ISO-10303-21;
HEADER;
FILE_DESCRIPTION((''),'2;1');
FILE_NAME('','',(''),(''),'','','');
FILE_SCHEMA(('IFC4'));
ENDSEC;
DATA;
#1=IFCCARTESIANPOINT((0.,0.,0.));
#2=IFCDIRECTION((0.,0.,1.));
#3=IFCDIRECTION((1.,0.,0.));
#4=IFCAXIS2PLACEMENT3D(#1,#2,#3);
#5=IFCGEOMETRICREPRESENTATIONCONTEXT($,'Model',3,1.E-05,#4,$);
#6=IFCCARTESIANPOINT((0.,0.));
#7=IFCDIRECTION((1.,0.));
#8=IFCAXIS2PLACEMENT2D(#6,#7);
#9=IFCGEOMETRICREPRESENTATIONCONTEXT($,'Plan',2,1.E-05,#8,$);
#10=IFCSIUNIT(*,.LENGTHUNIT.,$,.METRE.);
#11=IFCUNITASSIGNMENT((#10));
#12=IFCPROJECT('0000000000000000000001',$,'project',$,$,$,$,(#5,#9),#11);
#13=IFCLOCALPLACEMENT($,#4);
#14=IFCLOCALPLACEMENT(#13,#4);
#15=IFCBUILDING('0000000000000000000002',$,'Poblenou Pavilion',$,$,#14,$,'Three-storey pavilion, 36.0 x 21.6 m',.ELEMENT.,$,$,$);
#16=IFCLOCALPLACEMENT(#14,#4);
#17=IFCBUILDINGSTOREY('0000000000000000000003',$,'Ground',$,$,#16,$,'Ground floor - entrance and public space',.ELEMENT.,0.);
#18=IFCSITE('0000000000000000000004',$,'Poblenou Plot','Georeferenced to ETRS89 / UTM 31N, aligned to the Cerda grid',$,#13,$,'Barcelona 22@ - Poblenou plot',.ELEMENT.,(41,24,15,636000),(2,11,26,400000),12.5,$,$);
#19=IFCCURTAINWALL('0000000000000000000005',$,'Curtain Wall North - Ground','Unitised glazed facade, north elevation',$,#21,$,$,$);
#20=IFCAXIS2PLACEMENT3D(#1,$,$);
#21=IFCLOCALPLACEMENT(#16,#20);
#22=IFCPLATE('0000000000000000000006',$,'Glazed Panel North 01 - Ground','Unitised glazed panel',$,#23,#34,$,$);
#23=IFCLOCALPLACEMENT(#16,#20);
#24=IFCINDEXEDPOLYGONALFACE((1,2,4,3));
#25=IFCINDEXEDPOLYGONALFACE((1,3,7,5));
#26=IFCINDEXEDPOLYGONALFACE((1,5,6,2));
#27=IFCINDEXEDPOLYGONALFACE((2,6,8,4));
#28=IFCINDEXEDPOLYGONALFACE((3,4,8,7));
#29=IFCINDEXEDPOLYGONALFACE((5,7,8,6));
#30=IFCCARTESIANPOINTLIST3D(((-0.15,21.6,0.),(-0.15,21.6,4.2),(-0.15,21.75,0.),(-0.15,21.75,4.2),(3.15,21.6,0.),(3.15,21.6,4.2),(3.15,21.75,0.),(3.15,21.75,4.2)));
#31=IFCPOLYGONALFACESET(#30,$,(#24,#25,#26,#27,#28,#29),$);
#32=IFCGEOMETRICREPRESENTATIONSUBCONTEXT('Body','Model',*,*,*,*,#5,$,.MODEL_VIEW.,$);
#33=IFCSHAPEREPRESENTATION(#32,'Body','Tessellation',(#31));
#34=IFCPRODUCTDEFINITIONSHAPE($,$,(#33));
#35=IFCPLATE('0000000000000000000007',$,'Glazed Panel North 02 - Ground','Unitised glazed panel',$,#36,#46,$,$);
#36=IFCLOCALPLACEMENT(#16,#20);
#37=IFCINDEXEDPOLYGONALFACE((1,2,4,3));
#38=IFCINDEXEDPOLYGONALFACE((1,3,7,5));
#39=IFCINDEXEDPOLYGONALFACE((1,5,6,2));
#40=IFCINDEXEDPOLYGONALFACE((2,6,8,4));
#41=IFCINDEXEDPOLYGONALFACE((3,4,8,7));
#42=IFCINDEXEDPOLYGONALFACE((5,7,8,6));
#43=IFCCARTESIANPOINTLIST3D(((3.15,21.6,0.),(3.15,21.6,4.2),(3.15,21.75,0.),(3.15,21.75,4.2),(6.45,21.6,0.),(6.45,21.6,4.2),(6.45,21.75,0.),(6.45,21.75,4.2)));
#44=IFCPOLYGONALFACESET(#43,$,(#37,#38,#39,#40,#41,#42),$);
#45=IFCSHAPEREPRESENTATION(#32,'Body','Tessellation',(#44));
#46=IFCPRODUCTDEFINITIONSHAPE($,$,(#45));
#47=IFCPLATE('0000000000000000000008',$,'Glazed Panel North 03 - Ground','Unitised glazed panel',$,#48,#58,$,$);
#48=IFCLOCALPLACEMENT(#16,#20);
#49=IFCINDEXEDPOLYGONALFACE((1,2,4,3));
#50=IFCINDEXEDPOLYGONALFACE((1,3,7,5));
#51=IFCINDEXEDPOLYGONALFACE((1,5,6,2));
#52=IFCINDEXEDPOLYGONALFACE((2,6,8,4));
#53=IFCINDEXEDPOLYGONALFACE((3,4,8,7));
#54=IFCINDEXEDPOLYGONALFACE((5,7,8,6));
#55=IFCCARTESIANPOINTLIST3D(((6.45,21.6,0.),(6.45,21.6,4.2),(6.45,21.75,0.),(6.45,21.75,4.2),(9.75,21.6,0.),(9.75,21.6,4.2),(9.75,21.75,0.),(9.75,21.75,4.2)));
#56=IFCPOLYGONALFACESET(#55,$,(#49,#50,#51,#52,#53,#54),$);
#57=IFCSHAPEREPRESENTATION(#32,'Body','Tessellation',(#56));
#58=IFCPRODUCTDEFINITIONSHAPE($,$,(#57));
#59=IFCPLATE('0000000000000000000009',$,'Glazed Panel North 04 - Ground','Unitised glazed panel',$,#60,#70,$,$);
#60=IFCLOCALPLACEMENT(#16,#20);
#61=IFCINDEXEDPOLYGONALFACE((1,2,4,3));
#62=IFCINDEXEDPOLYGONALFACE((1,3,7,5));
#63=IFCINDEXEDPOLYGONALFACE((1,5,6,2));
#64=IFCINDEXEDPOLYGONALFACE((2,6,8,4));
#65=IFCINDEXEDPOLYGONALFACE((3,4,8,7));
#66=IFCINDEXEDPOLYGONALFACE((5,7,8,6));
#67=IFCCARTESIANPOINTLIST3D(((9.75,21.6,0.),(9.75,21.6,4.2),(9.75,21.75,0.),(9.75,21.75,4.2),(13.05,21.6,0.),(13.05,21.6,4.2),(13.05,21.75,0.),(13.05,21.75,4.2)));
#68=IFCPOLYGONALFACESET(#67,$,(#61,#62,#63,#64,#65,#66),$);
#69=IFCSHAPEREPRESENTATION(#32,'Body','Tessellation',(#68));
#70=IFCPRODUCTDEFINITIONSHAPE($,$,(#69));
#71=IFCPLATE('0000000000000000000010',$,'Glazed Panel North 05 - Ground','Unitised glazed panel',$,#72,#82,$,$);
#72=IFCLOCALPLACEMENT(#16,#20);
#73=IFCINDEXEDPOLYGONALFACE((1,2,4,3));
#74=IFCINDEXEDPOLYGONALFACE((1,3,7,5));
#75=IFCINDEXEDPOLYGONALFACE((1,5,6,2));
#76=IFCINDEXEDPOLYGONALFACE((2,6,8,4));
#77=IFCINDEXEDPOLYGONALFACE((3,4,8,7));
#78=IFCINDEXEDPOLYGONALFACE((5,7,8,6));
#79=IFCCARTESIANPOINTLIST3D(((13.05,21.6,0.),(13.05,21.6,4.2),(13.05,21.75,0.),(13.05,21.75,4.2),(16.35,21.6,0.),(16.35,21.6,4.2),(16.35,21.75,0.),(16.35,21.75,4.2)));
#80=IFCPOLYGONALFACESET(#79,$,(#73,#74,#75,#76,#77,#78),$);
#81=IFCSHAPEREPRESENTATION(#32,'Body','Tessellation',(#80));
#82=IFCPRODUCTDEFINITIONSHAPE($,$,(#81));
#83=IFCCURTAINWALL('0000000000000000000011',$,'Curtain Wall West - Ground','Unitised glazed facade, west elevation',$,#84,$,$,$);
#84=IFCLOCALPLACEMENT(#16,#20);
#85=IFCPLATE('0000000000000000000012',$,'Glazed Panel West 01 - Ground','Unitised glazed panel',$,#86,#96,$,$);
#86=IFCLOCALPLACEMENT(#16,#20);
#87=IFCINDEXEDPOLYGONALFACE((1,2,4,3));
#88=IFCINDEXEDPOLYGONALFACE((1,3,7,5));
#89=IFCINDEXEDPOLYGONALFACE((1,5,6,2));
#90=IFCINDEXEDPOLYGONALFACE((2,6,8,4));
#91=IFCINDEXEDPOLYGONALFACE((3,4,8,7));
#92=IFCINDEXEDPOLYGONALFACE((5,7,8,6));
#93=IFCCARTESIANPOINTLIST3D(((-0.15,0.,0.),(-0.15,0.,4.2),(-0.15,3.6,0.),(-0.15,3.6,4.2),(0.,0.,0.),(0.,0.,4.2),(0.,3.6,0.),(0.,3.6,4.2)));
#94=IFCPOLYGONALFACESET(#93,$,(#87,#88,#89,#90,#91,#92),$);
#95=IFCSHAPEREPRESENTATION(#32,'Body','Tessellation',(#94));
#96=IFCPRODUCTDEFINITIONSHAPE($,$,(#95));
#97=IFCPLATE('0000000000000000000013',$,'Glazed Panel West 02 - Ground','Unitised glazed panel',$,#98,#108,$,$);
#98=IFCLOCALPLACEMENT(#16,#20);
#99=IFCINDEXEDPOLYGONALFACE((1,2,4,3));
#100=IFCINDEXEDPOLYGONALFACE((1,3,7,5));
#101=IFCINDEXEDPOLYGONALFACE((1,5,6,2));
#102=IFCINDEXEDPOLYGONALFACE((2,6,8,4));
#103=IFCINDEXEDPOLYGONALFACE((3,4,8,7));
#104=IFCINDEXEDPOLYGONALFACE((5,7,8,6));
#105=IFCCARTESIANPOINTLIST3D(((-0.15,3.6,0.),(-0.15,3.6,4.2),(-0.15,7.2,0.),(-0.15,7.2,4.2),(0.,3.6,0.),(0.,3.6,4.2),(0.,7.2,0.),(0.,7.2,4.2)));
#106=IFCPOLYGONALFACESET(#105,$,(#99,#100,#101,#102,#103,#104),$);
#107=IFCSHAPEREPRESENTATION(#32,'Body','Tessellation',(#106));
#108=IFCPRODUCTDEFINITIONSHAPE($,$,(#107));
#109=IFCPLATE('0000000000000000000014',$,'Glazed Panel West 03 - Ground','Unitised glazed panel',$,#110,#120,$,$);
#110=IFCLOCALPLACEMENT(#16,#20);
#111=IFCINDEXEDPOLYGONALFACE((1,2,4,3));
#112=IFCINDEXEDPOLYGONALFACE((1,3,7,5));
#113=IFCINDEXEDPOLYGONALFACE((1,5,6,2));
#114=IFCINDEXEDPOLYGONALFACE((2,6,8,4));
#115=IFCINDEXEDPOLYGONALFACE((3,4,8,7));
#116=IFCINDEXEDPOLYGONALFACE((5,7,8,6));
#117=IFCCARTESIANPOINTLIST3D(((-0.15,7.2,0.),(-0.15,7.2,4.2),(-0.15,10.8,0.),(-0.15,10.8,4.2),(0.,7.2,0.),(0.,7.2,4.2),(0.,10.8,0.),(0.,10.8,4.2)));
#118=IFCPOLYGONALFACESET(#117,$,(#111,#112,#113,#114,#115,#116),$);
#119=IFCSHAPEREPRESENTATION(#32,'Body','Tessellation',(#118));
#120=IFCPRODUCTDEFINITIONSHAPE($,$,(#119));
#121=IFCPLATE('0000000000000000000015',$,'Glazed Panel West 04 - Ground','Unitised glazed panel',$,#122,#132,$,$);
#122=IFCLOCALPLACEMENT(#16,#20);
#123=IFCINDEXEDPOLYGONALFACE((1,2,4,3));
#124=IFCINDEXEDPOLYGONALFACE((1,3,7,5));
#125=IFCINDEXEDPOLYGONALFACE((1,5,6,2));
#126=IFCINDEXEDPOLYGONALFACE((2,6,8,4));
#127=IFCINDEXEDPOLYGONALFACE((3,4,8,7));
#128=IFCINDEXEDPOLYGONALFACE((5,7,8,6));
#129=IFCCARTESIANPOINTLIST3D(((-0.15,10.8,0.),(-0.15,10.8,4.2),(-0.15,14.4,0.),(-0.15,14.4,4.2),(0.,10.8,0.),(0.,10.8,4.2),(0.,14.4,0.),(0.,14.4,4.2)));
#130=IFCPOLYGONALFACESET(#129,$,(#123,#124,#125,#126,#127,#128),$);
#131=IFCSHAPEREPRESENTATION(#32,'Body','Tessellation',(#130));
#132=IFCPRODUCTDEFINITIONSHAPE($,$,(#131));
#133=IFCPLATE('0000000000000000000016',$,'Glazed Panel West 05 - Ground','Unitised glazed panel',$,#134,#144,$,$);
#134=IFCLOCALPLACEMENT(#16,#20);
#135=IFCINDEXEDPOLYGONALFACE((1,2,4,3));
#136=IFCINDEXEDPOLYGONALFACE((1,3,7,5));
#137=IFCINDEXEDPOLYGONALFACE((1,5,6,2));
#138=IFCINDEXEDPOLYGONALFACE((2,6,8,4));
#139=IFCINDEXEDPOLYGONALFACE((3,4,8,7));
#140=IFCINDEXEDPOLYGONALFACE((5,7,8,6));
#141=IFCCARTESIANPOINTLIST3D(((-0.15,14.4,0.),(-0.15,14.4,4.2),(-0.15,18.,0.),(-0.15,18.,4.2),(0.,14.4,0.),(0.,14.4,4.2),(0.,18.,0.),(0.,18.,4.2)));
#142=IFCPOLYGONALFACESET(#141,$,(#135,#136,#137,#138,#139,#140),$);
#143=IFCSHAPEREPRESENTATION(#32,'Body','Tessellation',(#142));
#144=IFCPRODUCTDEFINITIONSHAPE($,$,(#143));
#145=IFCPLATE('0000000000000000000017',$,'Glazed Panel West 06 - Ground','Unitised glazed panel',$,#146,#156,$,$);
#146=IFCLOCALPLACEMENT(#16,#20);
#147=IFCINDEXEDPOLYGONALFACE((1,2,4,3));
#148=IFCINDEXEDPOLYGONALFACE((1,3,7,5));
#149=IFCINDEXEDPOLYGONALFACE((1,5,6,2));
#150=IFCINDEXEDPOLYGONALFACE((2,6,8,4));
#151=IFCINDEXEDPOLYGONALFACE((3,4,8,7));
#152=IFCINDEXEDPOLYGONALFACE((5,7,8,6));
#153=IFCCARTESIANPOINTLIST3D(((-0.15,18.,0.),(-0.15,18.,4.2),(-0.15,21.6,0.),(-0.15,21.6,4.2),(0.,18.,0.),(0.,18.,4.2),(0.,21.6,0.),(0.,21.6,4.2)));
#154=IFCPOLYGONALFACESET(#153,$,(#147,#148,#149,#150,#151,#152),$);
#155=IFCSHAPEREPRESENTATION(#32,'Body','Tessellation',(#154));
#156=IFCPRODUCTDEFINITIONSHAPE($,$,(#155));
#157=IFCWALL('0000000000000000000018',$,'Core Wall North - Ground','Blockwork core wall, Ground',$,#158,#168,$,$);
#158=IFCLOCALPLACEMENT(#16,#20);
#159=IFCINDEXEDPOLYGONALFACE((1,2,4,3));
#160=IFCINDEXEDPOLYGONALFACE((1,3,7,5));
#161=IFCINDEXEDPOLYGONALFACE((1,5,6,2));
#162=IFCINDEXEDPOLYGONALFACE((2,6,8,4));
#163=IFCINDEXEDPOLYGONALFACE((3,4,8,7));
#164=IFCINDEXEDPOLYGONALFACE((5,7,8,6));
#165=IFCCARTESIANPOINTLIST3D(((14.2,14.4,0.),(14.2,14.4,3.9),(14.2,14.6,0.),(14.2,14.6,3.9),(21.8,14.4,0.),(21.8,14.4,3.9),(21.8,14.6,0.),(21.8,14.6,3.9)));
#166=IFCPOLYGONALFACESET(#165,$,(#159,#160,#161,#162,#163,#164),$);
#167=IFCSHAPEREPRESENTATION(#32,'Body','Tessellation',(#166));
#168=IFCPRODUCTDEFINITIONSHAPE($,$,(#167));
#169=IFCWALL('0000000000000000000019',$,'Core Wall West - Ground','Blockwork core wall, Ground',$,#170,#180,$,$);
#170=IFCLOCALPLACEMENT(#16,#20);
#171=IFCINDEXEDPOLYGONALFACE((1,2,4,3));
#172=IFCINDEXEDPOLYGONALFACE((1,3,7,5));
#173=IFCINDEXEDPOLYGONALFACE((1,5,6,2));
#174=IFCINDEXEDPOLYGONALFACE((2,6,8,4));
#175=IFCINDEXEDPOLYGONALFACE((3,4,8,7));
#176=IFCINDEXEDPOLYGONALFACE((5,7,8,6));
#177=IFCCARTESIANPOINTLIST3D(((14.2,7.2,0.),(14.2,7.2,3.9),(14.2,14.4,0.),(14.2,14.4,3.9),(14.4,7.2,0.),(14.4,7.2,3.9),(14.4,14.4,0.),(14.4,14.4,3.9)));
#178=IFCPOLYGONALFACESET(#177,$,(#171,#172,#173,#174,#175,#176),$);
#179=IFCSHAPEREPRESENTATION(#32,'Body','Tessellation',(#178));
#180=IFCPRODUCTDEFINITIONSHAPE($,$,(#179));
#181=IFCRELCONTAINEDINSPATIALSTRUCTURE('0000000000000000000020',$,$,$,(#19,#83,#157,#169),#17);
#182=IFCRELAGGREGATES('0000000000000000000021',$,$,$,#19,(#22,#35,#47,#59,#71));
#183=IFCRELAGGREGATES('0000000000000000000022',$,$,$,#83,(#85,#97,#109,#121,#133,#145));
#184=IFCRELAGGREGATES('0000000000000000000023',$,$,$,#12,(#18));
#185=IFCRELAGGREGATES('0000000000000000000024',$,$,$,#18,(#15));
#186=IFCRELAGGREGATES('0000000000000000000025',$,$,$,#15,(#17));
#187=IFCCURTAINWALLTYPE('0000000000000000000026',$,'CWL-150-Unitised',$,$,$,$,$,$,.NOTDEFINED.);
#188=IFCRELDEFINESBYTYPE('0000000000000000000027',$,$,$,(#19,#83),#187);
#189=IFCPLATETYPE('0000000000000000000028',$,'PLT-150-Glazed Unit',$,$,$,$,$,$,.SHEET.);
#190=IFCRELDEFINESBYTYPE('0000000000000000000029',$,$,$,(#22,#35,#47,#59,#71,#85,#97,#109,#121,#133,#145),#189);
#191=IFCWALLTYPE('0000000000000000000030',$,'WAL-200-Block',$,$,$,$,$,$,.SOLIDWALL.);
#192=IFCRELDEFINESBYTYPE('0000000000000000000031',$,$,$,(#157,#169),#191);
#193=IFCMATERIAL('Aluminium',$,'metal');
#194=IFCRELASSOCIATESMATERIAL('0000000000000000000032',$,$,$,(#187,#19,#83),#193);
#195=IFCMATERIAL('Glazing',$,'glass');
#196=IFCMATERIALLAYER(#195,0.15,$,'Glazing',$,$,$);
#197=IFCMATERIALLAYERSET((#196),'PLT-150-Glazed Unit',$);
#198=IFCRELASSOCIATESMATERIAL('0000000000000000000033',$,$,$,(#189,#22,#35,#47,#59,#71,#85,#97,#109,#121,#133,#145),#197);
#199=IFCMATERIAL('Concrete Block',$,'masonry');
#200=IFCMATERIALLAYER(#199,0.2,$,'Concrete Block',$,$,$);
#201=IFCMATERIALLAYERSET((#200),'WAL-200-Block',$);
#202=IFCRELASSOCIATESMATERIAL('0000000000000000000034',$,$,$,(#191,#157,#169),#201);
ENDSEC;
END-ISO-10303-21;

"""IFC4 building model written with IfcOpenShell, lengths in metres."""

from ifc_helpers import new_model, si_unit, frame, origin_with_axes, origin_2d_with_axis, place, context, subcontext, project, spatial, line, indexed_curve, outline, extrude, material, layer, layer_set, layer_usage, type_object, element, aggregate, save


model = new_model("IFC4")

# Units and contexts
model_context = context("Model", 3, precision=1e-05, world=origin_with_axes())
plan_context = context("Plan", 2, precision=1e-05, world=origin_2d_with_axis())
body_context = subcontext(model_context, "Body", "Model", "MODEL_VIEW")
ifc_project = project(units=[si_unit("LENGTHUNIT", "METRE")], contexts=[model_context, plan_context])

# Site, building, storey
site_placement = place(None, origin_with_axes())
site = spatial("IfcSite", under=ifc_project, at=site_placement, Name="Poblenou Plot", Description="Georeferenced to ETRS89 / UTM 31N, aligned to the Cerda grid", LongName="Barcelona 22@ - Poblenou plot", CompositionType="ELEMENT", RefLatitude=(41, 24, 15, 636000), RefLongitude=(2, 11, 26, 400000), RefElevation=12.5)
building_placement = place(site_placement, origin_with_axes())
building = spatial("IfcBuilding", under=site, at=building_placement, Name="Poblenou Pavilion", LongName="Three-storey pavilion, 36.0 x 21.6 m", CompositionType="ELEMENT")
storey_placement = place(building_placement, origin_with_axes())
storey = spatial("IfcBuildingStorey", under=building, at=storey_placement, Name="Ground", LongName="Ground floor - entrance and public space", CompositionType="ELEMENT", Elevation=0.0)

# Curtain walls, plates
ifc_material_1 = material(Name="Aluminium", Category="metal")
curtain_wall_type = type_object("IfcCurtainWallType", Name="CWL-150-Unitised", PredefinedType="NOTDEFINED", material=ifc_material_1)
ifc_material_2 = material(Name="Glazing", Category="glass")
ifc_layer_1 = layer(ifc_material_2, 0.15, Name="Glazing")
ifc_layer_set_1 = layer_set([ifc_layer_1], Name="PLT-150-Glazed Unit")
plate_type = type_object("IfcPlateType", Name="PLT-150-Glazed Unit", PredefinedType="SHEET", material=ifc_layer_set_1)
curtain_wall_1_placement = place(storey_placement, frame((-0.15, 21.6, 0.0), z_axis=(0.0, 0.0, 1.0), x_axis=(1.0, 0.0, 0.0)))
curtain_wall_1 = element("IfcCurtainWall", 1, at=curtain_wall_1_placement, inside=storey, type_object=curtain_wall_type, material=ifc_material_1, Name="Curtain Wall North - Ground", Description="Unitised glazed facade, north elevation")
ifc_layer_usage_1 = layer_usage(ifc_layer_set_1, "AXIS2", "POSITIVE", 0.0)
plate_1_placement = place(curtain_wall_1_placement, origin_with_axes())
plate_1 = element("IfcPlate", 2, at=plate_1_placement, type_object=plate_type, material=ifc_layer_usage_1, Name="Glazed Panel North 01 - Ground", Description="Unitised glazed panel", context=body_context, shape_type="SweptSolid", body=[
    extrude(outline(indexed_curve([(0.0, 0.0), (3.3, 0.0), (3.3, 0.15), (0.0, 0.15)], segments=[line(1, 2, 3, 4, 1)])), origin_with_axes(), (0.0, 0.0, 1.0), 4.2),
])
ifc_layer_usage_2 = layer_usage(ifc_layer_set_1, "AXIS2", "POSITIVE", 0.0)
plate_2_placement = place(curtain_wall_1_placement, frame((3.3, 0.0, 0.0), z_axis=(0.0, 0.0, 1.0), x_axis=(1.0, 0.0, 0.0)))
plate_2 = element("IfcPlate", 3, at=plate_2_placement, type_object=plate_type, material=ifc_layer_usage_2, Name="Glazed Panel North 02 - Ground", Description="Unitised glazed panel", context=body_context, shape_type="SweptSolid", body=[
    extrude(outline(indexed_curve([(0.0, 0.0), (3.3, 0.0), (3.3, 0.15), (0.0, 0.15)], segments=[line(1, 2, 3, 4, 1)])), origin_with_axes(), (0.0, 0.0, 1.0), 4.2),
])
ifc_layer_usage_3 = layer_usage(ifc_layer_set_1, "AXIS2", "POSITIVE", 0.0)
plate_3_placement = place(curtain_wall_1_placement, frame((6.6, 0.0, 0.0), z_axis=(0.0, 0.0, 1.0), x_axis=(1.0, 0.0, 0.0)))
plate_3 = element("IfcPlate", 4, at=plate_3_placement, type_object=plate_type, material=ifc_layer_usage_3, Name="Glazed Panel North 03 - Ground", Description="Unitised glazed panel", context=body_context, shape_type="SweptSolid", body=[
    extrude(outline(indexed_curve([(0.0, 0.0), (3.3, 0.0), (3.3, 0.15), (0.0, 0.15)], segments=[line(1, 2, 3, 4, 1)])), origin_with_axes(), (0.0, 0.0, 1.0), 4.2),
])
ifc_layer_usage_4 = layer_usage(ifc_layer_set_1, "AXIS2", "POSITIVE", 0.0)
plate_4_placement = place(curtain_wall_1_placement, frame((9.9, 0.0, 0.0), z_axis=(0.0, 0.0, 1.0), x_axis=(1.0, 0.0, 0.0)))
plate_4 = element("IfcPlate", 5, at=plate_4_placement, type_object=plate_type, material=ifc_layer_usage_4, Name="Glazed Panel North 04 - Ground", Description="Unitised glazed panel", context=body_context, shape_type="SweptSolid", body=[
    extrude(outline(indexed_curve([(0.0, 0.0), (3.3, 0.0), (3.3, 0.15), (0.0, 0.15)], segments=[line(1, 2, 3, 4, 1)])), origin_with_axes(), (0.0, 0.0, 1.0), 4.2),
])
ifc_layer_usage_5 = layer_usage(ifc_layer_set_1, "AXIS2", "POSITIVE", 0.0)
plate_5_placement = place(curtain_wall_1_placement, frame((13.2, 0.0, 0.0), z_axis=(0.0, 0.0, 1.0), x_axis=(1.0, 0.0, 0.0)))
plate_5 = element("IfcPlate", 6, at=plate_5_placement, type_object=plate_type, material=ifc_layer_usage_5, Name="Glazed Panel North 05 - Ground", Description="Unitised glazed panel", context=body_context, shape_type="SweptSolid", body=[
    extrude(outline(indexed_curve([(0.0, 0.0), (3.3, 0.0), (3.3, 0.15), (0.0, 0.15)], segments=[line(1, 2, 3, 4, 1)])), origin_with_axes(), (0.0, 0.0, 1.0), 4.2),
])
aggregate(curtain_wall_1, [plate_1, plate_2, plate_3, plate_4, plate_5])
curtain_wall_2_placement = place(storey_placement, frame((0.0, 0.0, 0.0), z_axis=(0.0, 0.0, 1.0), x_axis=(0.0, 1.0, 0.0)))
curtain_wall_2 = element("IfcCurtainWall", 7, at=curtain_wall_2_placement, inside=storey, type_object=curtain_wall_type, material=ifc_material_1, Name="Curtain Wall West - Ground", Description="Unitised glazed facade, west elevation")
ifc_layer_usage_6 = layer_usage(ifc_layer_set_1, "AXIS2", "POSITIVE", 0.0)
plate_6_placement = place(curtain_wall_2_placement, origin_with_axes())
plate_6 = element("IfcPlate", 8, at=plate_6_placement, type_object=plate_type, material=ifc_layer_usage_6, Name="Glazed Panel West 01 - Ground", Description="Unitised glazed panel", context=body_context, shape_type="SweptSolid", body=[
    extrude(outline(indexed_curve([(0.0, 0.0), (3.6, 0.0), (3.6, 0.15), (0.0, 0.15)], segments=[line(1, 2, 3, 4, 1)])), origin_with_axes(), (0.0, 0.0, 1.0), 4.2),
])
ifc_layer_usage_7 = layer_usage(ifc_layer_set_1, "AXIS2", "POSITIVE", 0.0)
plate_7_placement = place(curtain_wall_2_placement, frame((3.6, 0.0, 0.0), z_axis=(0.0, 0.0, 1.0), x_axis=(1.0, 0.0, 0.0)))
plate_7 = element("IfcPlate", 9, at=plate_7_placement, type_object=plate_type, material=ifc_layer_usage_7, Name="Glazed Panel West 02 - Ground", Description="Unitised glazed panel", context=body_context, shape_type="SweptSolid", body=[
    extrude(outline(indexed_curve([(0.0, 0.0), (3.6, 0.0), (3.6, 0.15), (0.0, 0.15)], segments=[line(1, 2, 3, 4, 1)])), origin_with_axes(), (0.0, 0.0, 1.0), 4.2),
])
ifc_layer_usage_8 = layer_usage(ifc_layer_set_1, "AXIS2", "POSITIVE", 0.0)
plate_8_placement = place(curtain_wall_2_placement, frame((7.2, 0.0, 0.0), z_axis=(0.0, 0.0, 1.0), x_axis=(1.0, 0.0, 0.0)))
plate_8 = element("IfcPlate", 10, at=plate_8_placement, type_object=plate_type, material=ifc_layer_usage_8, Name="Glazed Panel West 03 - Ground", Description="Unitised glazed panel", context=body_context, shape_type="SweptSolid", body=[
    extrude(outline(indexed_curve([(0.0, 0.0), (3.6, 0.0), (3.6, 0.15), (0.0, 0.15)], segments=[line(1, 2, 3, 4, 1)])), origin_with_axes(), (0.0, 0.0, 1.0), 4.2),
])
ifc_layer_usage_9 = layer_usage(ifc_layer_set_1, "AXIS2", "POSITIVE", 0.0)
plate_9_placement = place(curtain_wall_2_placement, frame((10.8, 0.0, 0.0), z_axis=(0.0, 0.0, 1.0), x_axis=(1.0, 0.0, 0.0)))
plate_9 = element("IfcPlate", 11, at=plate_9_placement, type_object=plate_type, material=ifc_layer_usage_9, Name="Glazed Panel West 04 - Ground", Description="Unitised glazed panel", context=body_context, shape_type="SweptSolid", body=[
    extrude(outline(indexed_curve([(0.0, 0.0), (3.6, 0.0), (3.6, 0.15), (0.0, 0.15)], segments=[line(1, 2, 3, 4, 1)])), origin_with_axes(), (0.0, 0.0, 1.0), 4.2),
])
ifc_layer_usage_10 = layer_usage(ifc_layer_set_1, "AXIS2", "POSITIVE", 0.0)
plate_10_placement = place(curtain_wall_2_placement, frame((14.4, 0.0, 0.0), z_axis=(0.0, 0.0, 1.0), x_axis=(1.0, 0.0, 0.0)))
plate_10 = element("IfcPlate", 12, at=plate_10_placement, type_object=plate_type, material=ifc_layer_usage_10, Name="Glazed Panel West 05 - Ground", Description="Unitised glazed panel", context=body_context, shape_type="SweptSolid", body=[
    extrude(outline(indexed_curve([(0.0, 0.0), (3.6, 0.0), (3.6, 0.15), (0.0, 0.15)], segments=[line(1, 2, 3, 4, 1)])), origin_with_axes(), (0.0, 0.0, 1.0), 4.2),
])
ifc_layer_usage_11 = layer_usage(ifc_layer_set_1, "AXIS2", "POSITIVE", 0.0)
plate_11_placement = place(curtain_wall_2_placement, frame((18.0, 0.0, 0.0), z_axis=(0.0, 0.0, 1.0), x_axis=(1.0, 0.0, 0.0)))
plate_11 = element("IfcPlate", 13, at=plate_11_placement, type_object=plate_type, material=ifc_layer_usage_11, Name="Glazed Panel West 06 - Ground", Description="Unitised glazed panel", context=body_context, shape_type="SweptSolid", body=[
    extrude(outline(indexed_curve([(0.0, 0.0), (3.6, 0.0), (3.6, 0.15), (0.0, 0.15)], segments=[line(1, 2, 3, 4, 1)])), origin_with_axes(), (0.0, 0.0, 1.0), 4.2),
])
aggregate(curtain_wall_2, [plate_6, plate_7, plate_8, plate_9, plate_10, plate_11])

# Walls
ifc_material_3 = material(Name="Concrete Block", Category="masonry")
ifc_layer_2 = layer(ifc_material_3, 0.2, Name="Concrete Block")
ifc_layer_set_2 = layer_set([ifc_layer_2], Name="WAL-200-Block")
ifc_layer_usage_12 = layer_usage(ifc_layer_set_2, "AXIS2", "POSITIVE", 0.0)
wall_type = type_object("IfcWallType", Name="WAL-200-Block", PredefinedType="SOLIDWALL", material=ifc_layer_set_2)
wall_1_placement = place(storey_placement, frame((14.2, 14.4, 0.0), z_axis=(0.0, 0.0, 1.0), x_axis=(1.0, 0.0, 0.0)))
element("IfcWall", 14, at=wall_1_placement, inside=storey, type_object=wall_type, material=ifc_layer_usage_12, Name="Core Wall North - Ground", Description="Blockwork core wall, Ground", context=body_context, shape_type="SweptSolid", body=[
    extrude(outline(indexed_curve([(0.0, 0.0), (7.6, 0.0), (7.6, 0.2), (0.0, 0.2)], segments=[line(1, 2, 3, 4, 1)])), origin_with_axes(), (0.0, 0.0, 1.0), 3.9),
])
ifc_layer_usage_13 = layer_usage(ifc_layer_set_2, "AXIS2", "POSITIVE", 0.0)
wall_2_placement = place(storey_placement, frame((14.4, 7.2, 0.0), z_axis=(0.0, 0.0, 1.0), x_axis=(0.0, 1.0, 0.0)))
element("IfcWall", 15, at=wall_2_placement, inside=storey, type_object=wall_type, material=ifc_layer_usage_13, Name="Core Wall West - Ground", Description="Blockwork core wall, Ground", context=body_context, shape_type="SweptSolid", body=[
    extrude(outline(indexed_curve([(0.0, 0.0), (7.2, 0.0), (7.2, 0.2), (0.0, 0.2)], segments=[line(1, 2, 3, 4, 1)])), origin_with_axes(), (0.0, 0.0, 1.0), 3.9),
])

save(model, "model.ifc")
